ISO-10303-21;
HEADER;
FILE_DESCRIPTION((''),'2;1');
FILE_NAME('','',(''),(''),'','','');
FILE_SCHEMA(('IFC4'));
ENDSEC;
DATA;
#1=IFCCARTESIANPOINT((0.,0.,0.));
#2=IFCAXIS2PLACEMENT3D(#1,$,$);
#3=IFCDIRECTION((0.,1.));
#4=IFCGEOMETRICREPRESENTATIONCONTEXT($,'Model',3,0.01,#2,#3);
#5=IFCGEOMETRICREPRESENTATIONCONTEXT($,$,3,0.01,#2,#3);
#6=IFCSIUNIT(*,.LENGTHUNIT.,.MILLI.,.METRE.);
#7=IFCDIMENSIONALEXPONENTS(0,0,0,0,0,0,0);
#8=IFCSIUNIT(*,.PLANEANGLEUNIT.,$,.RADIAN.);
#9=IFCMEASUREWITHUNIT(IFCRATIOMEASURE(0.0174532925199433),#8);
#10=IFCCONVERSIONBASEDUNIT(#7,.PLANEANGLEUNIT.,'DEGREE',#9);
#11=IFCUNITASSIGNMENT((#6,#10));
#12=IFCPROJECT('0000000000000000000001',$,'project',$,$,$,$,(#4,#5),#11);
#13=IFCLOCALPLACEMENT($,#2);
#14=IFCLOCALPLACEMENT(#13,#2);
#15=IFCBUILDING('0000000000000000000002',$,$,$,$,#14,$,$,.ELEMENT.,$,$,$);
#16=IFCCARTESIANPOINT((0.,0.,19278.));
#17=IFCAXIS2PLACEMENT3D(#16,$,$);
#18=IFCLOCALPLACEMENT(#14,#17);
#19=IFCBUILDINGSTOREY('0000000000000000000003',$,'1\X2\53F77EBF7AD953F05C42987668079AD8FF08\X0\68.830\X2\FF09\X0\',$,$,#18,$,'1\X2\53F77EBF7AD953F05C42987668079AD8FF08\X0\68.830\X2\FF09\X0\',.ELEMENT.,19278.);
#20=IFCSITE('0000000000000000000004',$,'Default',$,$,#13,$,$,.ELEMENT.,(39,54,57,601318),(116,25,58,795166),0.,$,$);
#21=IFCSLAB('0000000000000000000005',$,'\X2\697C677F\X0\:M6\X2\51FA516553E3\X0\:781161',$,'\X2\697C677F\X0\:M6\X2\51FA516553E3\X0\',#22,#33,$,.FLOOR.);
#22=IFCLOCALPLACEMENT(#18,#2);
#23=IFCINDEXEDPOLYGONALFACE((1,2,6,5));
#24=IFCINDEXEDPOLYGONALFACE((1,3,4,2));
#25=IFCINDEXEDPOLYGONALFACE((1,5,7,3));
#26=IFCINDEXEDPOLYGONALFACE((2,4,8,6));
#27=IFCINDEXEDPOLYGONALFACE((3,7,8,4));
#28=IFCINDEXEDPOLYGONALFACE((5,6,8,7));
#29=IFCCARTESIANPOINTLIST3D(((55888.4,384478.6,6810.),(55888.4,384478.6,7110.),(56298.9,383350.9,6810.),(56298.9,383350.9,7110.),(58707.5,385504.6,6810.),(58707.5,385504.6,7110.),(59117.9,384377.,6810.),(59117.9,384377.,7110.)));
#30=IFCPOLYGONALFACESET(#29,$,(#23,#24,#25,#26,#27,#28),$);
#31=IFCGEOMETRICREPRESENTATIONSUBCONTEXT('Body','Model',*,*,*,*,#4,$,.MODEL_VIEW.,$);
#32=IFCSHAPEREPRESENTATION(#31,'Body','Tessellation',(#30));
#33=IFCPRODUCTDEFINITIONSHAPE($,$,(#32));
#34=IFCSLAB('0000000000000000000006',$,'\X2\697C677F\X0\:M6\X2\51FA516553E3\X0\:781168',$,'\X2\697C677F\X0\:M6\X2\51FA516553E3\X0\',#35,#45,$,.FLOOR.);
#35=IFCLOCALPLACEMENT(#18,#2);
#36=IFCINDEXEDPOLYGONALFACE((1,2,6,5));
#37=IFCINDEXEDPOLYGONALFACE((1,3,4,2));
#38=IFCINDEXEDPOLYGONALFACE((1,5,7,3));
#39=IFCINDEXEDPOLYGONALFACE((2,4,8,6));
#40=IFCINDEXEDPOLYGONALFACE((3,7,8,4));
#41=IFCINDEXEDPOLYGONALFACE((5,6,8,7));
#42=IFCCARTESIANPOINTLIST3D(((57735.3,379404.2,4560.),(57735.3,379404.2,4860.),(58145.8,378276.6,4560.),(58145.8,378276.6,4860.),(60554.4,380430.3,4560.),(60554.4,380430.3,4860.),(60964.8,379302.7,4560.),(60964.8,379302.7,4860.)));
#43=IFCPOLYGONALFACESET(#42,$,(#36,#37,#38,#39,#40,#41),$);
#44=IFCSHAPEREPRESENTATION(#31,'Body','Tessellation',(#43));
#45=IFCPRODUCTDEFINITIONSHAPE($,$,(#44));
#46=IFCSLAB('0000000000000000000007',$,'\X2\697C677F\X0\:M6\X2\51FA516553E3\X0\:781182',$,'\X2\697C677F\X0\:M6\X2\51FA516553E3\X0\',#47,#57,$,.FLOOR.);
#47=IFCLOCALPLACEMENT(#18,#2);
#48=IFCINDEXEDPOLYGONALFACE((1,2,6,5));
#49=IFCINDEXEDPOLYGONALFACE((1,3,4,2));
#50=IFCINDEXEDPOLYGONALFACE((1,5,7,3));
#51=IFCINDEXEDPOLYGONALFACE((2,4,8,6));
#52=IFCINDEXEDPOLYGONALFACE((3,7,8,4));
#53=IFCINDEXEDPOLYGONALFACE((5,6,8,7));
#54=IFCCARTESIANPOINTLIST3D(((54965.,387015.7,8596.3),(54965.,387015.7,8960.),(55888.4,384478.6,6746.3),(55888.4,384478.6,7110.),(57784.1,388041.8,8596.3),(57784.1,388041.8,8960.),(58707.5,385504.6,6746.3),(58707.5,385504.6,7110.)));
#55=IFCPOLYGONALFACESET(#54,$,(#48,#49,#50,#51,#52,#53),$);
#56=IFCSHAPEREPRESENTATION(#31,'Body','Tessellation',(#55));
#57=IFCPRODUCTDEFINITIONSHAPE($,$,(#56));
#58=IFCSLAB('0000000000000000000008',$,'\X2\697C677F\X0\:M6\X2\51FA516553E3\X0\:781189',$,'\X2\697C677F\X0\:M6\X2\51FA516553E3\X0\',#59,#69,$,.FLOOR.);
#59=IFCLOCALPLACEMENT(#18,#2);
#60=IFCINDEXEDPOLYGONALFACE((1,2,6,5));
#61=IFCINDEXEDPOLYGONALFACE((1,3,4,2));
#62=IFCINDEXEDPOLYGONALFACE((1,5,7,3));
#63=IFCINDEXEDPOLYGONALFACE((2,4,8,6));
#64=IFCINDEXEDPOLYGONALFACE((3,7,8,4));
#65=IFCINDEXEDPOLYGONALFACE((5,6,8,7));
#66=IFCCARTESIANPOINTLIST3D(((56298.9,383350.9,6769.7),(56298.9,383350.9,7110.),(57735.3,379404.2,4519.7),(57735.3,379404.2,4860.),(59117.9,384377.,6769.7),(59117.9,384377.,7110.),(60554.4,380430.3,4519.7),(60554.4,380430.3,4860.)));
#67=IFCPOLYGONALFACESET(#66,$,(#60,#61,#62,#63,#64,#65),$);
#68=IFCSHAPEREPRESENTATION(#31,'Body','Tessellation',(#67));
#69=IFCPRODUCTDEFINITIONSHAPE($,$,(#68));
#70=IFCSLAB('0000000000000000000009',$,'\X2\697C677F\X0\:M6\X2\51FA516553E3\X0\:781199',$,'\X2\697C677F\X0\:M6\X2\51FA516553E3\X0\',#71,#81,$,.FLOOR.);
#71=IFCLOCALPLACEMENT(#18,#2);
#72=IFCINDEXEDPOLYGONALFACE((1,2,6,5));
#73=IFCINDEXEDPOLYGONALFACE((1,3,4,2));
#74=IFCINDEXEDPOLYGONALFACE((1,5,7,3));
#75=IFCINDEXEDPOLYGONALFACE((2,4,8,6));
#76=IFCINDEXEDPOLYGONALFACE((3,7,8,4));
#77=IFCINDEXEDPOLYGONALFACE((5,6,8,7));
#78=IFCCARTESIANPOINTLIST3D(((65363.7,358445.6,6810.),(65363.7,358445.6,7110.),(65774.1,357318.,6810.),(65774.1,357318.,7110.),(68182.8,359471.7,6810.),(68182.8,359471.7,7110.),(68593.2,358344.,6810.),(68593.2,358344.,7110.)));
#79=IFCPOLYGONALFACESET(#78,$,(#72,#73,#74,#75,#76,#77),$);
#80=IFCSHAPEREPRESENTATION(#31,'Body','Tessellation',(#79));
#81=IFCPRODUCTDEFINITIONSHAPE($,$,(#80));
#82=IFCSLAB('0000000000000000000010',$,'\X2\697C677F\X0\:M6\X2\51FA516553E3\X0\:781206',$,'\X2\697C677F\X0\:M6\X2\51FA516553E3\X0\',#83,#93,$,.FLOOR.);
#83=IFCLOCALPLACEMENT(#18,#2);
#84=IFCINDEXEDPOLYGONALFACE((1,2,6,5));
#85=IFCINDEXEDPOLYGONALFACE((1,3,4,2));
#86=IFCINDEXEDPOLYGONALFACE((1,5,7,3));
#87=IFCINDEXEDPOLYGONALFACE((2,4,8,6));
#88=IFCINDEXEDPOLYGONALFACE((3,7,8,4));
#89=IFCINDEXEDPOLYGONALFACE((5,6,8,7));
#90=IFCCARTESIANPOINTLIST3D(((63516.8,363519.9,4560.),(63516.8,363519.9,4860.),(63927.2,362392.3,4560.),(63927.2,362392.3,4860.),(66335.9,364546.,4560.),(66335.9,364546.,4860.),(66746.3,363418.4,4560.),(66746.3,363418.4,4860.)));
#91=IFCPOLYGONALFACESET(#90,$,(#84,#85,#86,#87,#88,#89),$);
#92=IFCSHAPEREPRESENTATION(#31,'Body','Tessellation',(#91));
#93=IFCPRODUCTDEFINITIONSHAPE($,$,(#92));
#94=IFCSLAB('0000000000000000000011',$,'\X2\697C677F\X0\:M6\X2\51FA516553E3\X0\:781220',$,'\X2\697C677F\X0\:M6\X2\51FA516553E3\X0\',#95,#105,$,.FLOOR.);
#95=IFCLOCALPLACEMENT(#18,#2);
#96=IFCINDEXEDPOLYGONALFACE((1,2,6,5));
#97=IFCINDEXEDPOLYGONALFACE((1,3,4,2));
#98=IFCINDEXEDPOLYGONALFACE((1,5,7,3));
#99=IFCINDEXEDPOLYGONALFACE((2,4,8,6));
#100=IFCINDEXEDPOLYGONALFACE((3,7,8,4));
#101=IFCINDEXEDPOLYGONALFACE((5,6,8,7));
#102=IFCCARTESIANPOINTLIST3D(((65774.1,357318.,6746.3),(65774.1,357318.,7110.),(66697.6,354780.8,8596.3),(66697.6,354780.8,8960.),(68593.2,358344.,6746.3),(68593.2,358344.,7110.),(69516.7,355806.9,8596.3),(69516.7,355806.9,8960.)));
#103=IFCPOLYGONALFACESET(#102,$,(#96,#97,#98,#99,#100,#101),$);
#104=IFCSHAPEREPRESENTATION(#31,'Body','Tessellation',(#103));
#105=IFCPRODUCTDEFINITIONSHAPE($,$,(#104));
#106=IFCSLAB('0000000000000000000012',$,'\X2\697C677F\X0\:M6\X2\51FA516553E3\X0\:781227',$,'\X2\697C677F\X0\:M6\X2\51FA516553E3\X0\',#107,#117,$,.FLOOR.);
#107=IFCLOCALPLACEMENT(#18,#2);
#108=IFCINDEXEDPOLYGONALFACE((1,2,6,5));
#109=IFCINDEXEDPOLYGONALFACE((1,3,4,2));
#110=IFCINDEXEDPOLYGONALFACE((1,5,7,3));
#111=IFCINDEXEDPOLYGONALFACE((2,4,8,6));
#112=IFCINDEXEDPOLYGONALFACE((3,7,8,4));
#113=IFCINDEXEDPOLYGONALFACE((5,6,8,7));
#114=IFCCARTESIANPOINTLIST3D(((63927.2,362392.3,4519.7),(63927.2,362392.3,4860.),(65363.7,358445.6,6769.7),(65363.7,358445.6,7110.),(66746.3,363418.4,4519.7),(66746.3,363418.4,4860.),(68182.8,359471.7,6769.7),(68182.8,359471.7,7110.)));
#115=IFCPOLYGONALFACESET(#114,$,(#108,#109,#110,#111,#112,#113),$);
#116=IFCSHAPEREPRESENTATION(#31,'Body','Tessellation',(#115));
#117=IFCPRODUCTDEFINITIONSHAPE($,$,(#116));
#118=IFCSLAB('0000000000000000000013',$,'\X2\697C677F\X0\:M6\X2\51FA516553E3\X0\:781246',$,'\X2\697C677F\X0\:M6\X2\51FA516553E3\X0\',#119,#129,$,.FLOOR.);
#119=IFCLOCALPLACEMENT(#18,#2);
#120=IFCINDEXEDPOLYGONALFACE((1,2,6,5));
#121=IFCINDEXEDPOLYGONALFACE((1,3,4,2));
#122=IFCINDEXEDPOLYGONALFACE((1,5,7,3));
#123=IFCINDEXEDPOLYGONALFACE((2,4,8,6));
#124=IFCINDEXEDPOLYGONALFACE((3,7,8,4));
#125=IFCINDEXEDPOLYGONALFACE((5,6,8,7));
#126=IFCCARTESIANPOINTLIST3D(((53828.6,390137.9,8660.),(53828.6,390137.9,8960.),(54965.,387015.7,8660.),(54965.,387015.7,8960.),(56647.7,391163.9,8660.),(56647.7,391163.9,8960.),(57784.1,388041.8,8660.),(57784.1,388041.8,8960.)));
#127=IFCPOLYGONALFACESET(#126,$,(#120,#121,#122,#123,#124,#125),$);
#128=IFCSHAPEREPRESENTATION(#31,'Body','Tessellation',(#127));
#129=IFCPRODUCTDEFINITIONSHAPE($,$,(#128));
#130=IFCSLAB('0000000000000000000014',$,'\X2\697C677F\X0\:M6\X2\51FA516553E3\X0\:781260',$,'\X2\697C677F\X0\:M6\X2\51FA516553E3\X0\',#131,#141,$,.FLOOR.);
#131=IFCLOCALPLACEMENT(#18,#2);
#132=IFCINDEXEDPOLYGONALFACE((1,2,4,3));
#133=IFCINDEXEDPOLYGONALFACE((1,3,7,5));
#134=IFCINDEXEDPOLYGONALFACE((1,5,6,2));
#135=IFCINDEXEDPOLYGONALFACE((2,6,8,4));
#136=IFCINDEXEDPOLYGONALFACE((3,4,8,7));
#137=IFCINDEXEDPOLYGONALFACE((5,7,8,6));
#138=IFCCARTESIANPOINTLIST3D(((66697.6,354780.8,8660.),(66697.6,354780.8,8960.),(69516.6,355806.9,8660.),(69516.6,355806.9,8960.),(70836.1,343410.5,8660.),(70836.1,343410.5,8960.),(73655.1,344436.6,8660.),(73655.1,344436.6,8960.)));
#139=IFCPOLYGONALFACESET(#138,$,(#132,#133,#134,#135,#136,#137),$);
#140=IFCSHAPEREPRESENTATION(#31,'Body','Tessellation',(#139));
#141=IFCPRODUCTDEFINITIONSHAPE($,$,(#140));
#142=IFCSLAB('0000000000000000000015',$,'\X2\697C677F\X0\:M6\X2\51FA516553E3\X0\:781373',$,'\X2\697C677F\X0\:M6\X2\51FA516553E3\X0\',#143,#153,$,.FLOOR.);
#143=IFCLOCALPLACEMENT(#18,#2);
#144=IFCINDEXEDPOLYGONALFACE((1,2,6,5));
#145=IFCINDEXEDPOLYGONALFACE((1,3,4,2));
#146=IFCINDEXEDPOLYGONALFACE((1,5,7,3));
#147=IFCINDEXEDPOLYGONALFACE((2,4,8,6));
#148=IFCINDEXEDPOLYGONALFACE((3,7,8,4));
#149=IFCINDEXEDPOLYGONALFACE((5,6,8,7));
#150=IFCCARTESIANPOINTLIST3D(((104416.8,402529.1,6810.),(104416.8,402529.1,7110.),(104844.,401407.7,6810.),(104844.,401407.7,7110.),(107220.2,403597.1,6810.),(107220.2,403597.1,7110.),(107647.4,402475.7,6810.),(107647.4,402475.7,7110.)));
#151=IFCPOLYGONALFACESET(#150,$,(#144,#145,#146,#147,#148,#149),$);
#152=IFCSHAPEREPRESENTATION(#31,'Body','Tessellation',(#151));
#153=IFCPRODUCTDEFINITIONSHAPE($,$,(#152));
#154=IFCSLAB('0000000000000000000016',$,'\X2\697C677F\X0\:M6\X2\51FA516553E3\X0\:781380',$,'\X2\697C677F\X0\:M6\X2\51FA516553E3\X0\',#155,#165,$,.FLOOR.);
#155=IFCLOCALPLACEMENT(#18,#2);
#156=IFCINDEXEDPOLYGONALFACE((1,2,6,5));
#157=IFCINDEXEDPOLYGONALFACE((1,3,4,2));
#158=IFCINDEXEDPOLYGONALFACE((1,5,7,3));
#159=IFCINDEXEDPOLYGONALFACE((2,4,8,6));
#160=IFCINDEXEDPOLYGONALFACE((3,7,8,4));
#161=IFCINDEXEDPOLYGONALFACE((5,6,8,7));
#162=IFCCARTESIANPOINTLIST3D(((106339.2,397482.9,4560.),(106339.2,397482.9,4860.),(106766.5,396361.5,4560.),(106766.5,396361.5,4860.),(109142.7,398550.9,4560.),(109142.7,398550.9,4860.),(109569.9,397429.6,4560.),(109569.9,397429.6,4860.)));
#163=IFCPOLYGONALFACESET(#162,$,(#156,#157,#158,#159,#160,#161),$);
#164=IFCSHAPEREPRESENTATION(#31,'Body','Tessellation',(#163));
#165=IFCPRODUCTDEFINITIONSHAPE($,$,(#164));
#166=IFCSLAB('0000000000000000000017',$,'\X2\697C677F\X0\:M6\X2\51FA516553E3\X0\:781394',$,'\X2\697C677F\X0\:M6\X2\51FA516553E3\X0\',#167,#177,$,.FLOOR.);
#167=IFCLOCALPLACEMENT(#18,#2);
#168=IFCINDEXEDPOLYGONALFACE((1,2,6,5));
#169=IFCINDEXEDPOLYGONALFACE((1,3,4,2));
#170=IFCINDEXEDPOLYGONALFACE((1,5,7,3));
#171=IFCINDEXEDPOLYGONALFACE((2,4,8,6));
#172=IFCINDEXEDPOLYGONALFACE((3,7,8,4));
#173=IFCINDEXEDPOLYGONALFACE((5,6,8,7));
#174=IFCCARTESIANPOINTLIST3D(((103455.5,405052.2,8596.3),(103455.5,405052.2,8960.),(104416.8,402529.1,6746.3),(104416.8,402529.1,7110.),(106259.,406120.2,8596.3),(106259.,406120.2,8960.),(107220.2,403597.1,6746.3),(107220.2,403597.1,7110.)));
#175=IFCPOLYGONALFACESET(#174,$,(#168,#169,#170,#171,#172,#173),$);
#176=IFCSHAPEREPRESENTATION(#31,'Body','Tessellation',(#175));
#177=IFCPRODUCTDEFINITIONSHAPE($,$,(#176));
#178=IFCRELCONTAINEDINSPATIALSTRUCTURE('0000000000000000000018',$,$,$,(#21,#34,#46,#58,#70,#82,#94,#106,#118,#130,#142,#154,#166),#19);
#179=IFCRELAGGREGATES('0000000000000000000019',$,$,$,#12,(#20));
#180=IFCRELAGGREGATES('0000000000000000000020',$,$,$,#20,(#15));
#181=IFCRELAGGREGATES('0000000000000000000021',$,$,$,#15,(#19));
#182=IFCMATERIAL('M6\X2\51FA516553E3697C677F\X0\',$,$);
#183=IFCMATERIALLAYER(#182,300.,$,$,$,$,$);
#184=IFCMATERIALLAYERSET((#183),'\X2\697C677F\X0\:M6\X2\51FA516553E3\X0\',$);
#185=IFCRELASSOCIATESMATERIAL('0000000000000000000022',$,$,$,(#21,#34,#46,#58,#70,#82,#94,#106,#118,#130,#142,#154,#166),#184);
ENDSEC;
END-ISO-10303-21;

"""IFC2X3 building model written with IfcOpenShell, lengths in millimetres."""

from ifc_helpers import new_model, entity, si_unit, converted_unit, direction, frame, frame_2d, origin, place, context, subcontext, project, spatial, polyline, rectangle, outline, extrude, clip, halfspace, material, layer, layer_set, layer_usage, element, save


model = new_model("IFC2X3")

# Units and contexts
model_context = context("Model", 3, precision=0.01, world=origin(), true_north=direction((0.0, 1.0)))
context_of_model = context(None, 3, precision=0.01, world=origin(), true_north=direction((0.0, 1.0)))
body_context = subcontext(model_context, "Body", "Model", "MODEL_VIEW")
ifc_project = project(units=[si_unit("LENGTHUNIT", "METRE", prefix="MILLI"), converted_unit("PLANEANGLEUNIT", "DEGREE", entity("IfcRatioMeasure", 0.0174532925199433), si_unit("PLANEANGLEUNIT", "RADIAN"), dimensions=[0, 0, 0, 0, 0, 0, 0])], contexts=[model_context, context_of_model])

# Site, building, storey
site_placement = place(None, origin())
site = spatial("IfcSite", under=ifc_project, at=site_placement, Name="Default", CompositionType="ELEMENT", RefLatitude=(39, 54, 57, 601318), RefLongitude=(116, 25, 58, 795166), RefElevation=0.0)
building_placement = place(site_placement, origin())
building = spatial("IfcBuilding", under=site, at=building_placement, CompositionType="ELEMENT")
storey_placement = place(building_placement, frame((0.0, 0.0, 19278.0)))
storey = spatial("IfcBuildingStorey", under=building, at=storey_placement, Name="1号线站台层顶标高（68.830）", LongName="1号线站台层顶标高（68.830）", CompositionType="ELEMENT", Elevation=19278.0)

# Slabs
ifc_material_1 = material(Name="M6出入口楼板")
ifc_layer_1 = layer(ifc_material_1, 300.0)
ifc_layer_set_1 = layer_set([ifc_layer_1], Name="楼板:M6出入口")
ifc_layer_usage_1 = layer_usage(ifc_layer_set_1, "AXIS3", "POSITIVE", 0.0)
slab_1_placement = place(storey_placement, origin())
element("IfcSlab", 1, at=slab_1_placement, inside=storey, material=ifc_layer_usage_1, Name="楼板:M6出入口:781161", ObjectType="楼板:M6出入口", PredefinedType="FLOOR", context=body_context, shape_type="SweptSolid", body=[
    extrude(rectangle(XDim=1200.0, YDim=3000.0, at=frame_2d((0.0, 0.0), x_axis=(1.0, 0.0))), frame((57503.2, 384427.8, 7110.0), z_axis=(0.0, 0.0, -1.0), x_axis=(0.34202, -0.939693, 0.0)), (0.0, 0.0, 1.0), 300.0),
])
ifc_layer_usage_2 = layer_usage(ifc_layer_set_1, "AXIS3", "POSITIVE", 0.0)
slab_2_placement = place(storey_placement, origin())
element("IfcSlab", 2, at=slab_2_placement, inside=storey, material=ifc_layer_usage_2, Name="楼板:M6出入口:781168", ObjectType="楼板:M6出入口", PredefinedType="FLOOR", context=body_context, shape_type="SweptSolid", body=[
    extrude(rectangle(XDim=1200.0, YDim=3000.0, at=frame_2d((0.0, 0.0), x_axis=(1.0, 0.0))), frame((59350.1, 379353.4, 4860.0), z_axis=(0.0, 0.0, -1.0), x_axis=(0.34202, -0.939693, 0.0)), (0.0, 0.0, 1.0), 300.0),
])
ifc_layer_usage_3 = layer_usage(ifc_layer_set_1, "AXIS3", "POSITIVE", 0.0)
slab_3_placement = place(storey_placement, origin())
element("IfcSlab", 3, at=slab_3_placement, inside=storey, material=ifc_layer_usage_3, Name="楼板:M6出入口:781182", ObjectType="楼板:M6出入口", PredefinedType="FLOOR", context=body_context, shape_type="Clipping", body=[
    clip(clip(extrude(rectangle(XDim=3273.0, YDim=3000.0, at=frame_2d((0.0, 0.0), x_axis=(1.0, 0.0))), frame((56836.2, 386260.2, 8035.0), z_axis=(-0.193321, 0.531144, -0.824932), x_axis=(0.282143, -0.775183, -0.565231)), (0.565231, 0.0, 0.824932), 440.8), halfspace(frame((56374.5, 387528.8, 8596.3), z_axis=(-0.193321, 0.531144, -0.824932), x_axis=(0.981136, 0.104655, -0.162543)), False)), halfspace(frame((56374.5, 387528.8, 8960.0), z_axis=(0.193321, -0.531144, 0.824932), x_axis=(0.981136, 0.104655, -0.162543)), False)),
])
ifc_layer_usage_4 = layer_usage(ifc_layer_set_1, "AXIS3", "POSITIVE", 0.0)
slab_4_placement = place(storey_placement, origin())
element("IfcSlab", 4, at=slab_4_placement, inside=storey, material=ifc_layer_usage_4, Name="楼板:M6出入口:781189", ObjectType="楼板:M6出入口", PredefinedType="FLOOR", context=body_context, shape_type="Clipping", body=[
    clip(clip(extrude(rectangle(XDim=4764.7, YDim=3000.0, at=frame_2d((0.0, 0.0), x_axis=(1.0, 0.0))), frame((58426.6, 381890.6, 5985.0), z_axis=(-0.161509, 0.443743, -0.88148), x_axis=(0.301484, -0.82832, -0.472221)), (0.472221, 0.0, 0.88148), 386.1), halfspace(frame((57708.4, 383864.0, 6769.7), z_axis=(-0.161509, 0.443743, -0.88148), x_axis=(0.986871, 0.072622, -0.144261)), False)), halfspace(frame((57708.4, 383864.0, 7110.0), z_axis=(0.161509, -0.443743, 0.88148), x_axis=(0.986871, 0.072622, -0.144261)), False)),
])
ifc_layer_usage_5 = layer_usage(ifc_layer_set_1, "AXIS3", "POSITIVE", 0.0)
slab_5_placement = place(storey_placement, origin())
element("IfcSlab", 5, at=slab_5_placement, inside=storey, material=ifc_layer_usage_5, Name="楼板:M6出入口:781199", ObjectType="楼板:M6出入口", PredefinedType="FLOOR", context=body_context, shape_type="SweptSolid", body=[
    extrude(rectangle(XDim=1200.0, YDim=3000.0, at=frame_2d((0.0, 0.0), x_axis=(1.0, 0.0))), frame((66978.5, 358394.8, 7110.0), z_axis=(0.0, 0.0, -1.0), x_axis=(0.342025, -0.939691, 0.0)), (0.0, 0.0, 1.0), 300.0),
])
ifc_layer_usage_6 = layer_usage(ifc_layer_set_1, "AXIS3", "POSITIVE", 0.0)
slab_6_placement = place(storey_placement, origin())
element("IfcSlab", 6, at=slab_6_placement, inside=storey, material=ifc_layer_usage_6, Name="楼板:M6出入口:781206", ObjectType="楼板:M6出入口", PredefinedType="FLOOR", context=body_context, shape_type="SweptSolid", body=[
    extrude(rectangle(XDim=1200.0, YDim=3000.0, at=frame_2d((0.0, 0.0), x_axis=(1.0, 0.0))), frame((65131.5, 363469.1, 4860.0), z_axis=(0.0, 0.0, -1.0), x_axis=(0.342025, -0.939691, 0.0)), (0.0, 0.0, 1.0), 300.0),
])
ifc_layer_usage_7 = layer_usage(ifc_layer_set_1, "AXIS3", "POSITIVE", 0.0)
slab_7_placement = place(storey_placement, origin())
element("IfcSlab", 7, at=slab_7_placement, inside=storey, material=ifc_layer_usage_7, Name="楼板:M6出入口:781220", ObjectType="楼板:M6出入口", PredefinedType="FLOOR", context=body_context, shape_type="Clipping", body=[
    clip(clip(extrude(rectangle(XDim=3273.0, YDim=3000.0, at=frame_2d((0.0, 0.0), x_axis=(1.0, 0.0))), frame((67645.4, 356562.4, 8035.0), z_axis=(0.193323, -0.531143, -0.824932), x_axis=(0.282147, -0.775181, 0.565231)), (-0.565231, 0.0, 0.824932), 440.8), halfspace(frame((68107.1, 355293.8, 8596.3), z_axis=(0.193323, -0.531143, -0.824932), x_axis=(0.981135, 0.104657, 0.162545)), False)), halfspace(frame((68107.1, 355293.8, 8960.0), z_axis=(-0.193323, 0.531143, 0.824932), x_axis=(0.981135, 0.104657, 0.162545)), False)),
])
ifc_layer_usage_8 = layer_usage(ifc_layer_set_1, "AXIS3", "POSITIVE", 0.0)
slab_8_placement = place(storey_placement, origin())
element("IfcSlab", 8, at=slab_8_placement, inside=storey, material=ifc_layer_usage_8, Name="楼板:M6出入口:781227", ObjectType="楼板:M6出入口", PredefinedType="FLOOR", context=body_context, shape_type="Clipping", body=[
    clip(clip(extrude(rectangle(XDim=4764.7, YDim=3000.0, at=frame_2d((0.0, 0.0), x_axis=(1.0, 0.0))), frame((66055.0, 360932.0, 5985.0), z_axis=(0.161511, -0.443742, -0.88148), x_axis=(0.301488, -0.828319, 0.472221)), (-0.472221, 0.0, 0.88148), 386.1), halfspace(frame((66773.2, 358958.6, 6769.7), z_axis=(0.161511, -0.443742, -0.88148), x_axis=(0.986871, 0.072623, 0.144263)), False)), halfspace(frame((66773.2, 358958.6, 7110.0), z_axis=(-0.161511, 0.443742, 0.88148), x_axis=(0.986871, 0.072623, 0.144263)), False)),
])
ifc_layer_usage_9 = layer_usage(ifc_layer_set_1, "AXIS3", "POSITIVE", 0.0)
slab_9_placement = place(storey_placement, origin())
element("IfcSlab", 9, at=slab_9_placement, inside=storey, material=ifc_layer_usage_9, Name="楼板:M6出入口:781246", ObjectType="楼板:M6出入口", PredefinedType="FLOOR", context=body_context, shape_type="SweptSolid", body=[
    extrude(rectangle(XDim=3322.5, YDim=3000.0, at=frame_2d((0.0, 0.0), x_axis=(1.0, 0.0))), frame((55806.3, 389089.8, 8960.0), z_axis=(0.0, 0.0, -1.0), x_axis=(0.34202, -0.939693, 0.0)), (0.0, 0.0, 1.0), 300.0),
])
ifc_layer_usage_10 = layer_usage(ifc_layer_set_1, "AXIS3", "POSITIVE", 0.0)
slab_10_placement = place(storey_placement, origin())
element("IfcSlab", 10, at=slab_10_placement, inside=storey, material=ifc_layer_usage_10, Name="楼板:M6出入口:781260", ObjectType="楼板:M6出入口", PredefinedType="FLOOR", context=body_context, shape_type="SweptSolid", body=[
    extrude(outline(polyline([(-6050.0, -1500.0), (6050.0, -1500.0), (6050.0, 1500.0), (-6050.0, 1499.9), (-6050.0, -1500.0)])), frame((70176.3, 349608.7, 8960.0), z_axis=(0.0, 0.0, -1.0), x_axis=(0.342025, -0.939691, 0.0)), (0.0, 0.0, 1.0), 300.0),
])
ifc_layer_usage_11 = layer_usage(ifc_layer_set_1, "AXIS3", "POSITIVE", 0.0)
slab_11_placement = place(storey_placement, origin())
element("IfcSlab", 11, at=slab_11_placement, inside=storey, material=ifc_layer_usage_11, Name="楼板:M6出入口:781373", ObjectType="楼板:M6出入口", PredefinedType="FLOOR", context=body_context, shape_type="SweptSolid", body=[
    extrude(rectangle(XDim=3000.0, YDim=1200.0, at=frame_2d((0.0, 0.0), x_axis=(1.0, 0.0))), frame((106032.1, 402502.4, 7110.0), z_axis=(0.0, 0.0, -1.0), x_axis=(0.93448, 0.356017, 0.0)), (0.0, 0.0, 1.0), 300.0),
])
ifc_layer_usage_12 = layer_usage(ifc_layer_set_1, "AXIS3", "POSITIVE", 0.0)
slab_12_placement = place(storey_placement, origin())
element("IfcSlab", 12, at=slab_12_placement, inside=storey, material=ifc_layer_usage_12, Name="楼板:M6出入口:781380", ObjectType="楼板:M6出入口", PredefinedType="FLOOR", context=body_context, shape_type="SweptSolid", body=[
    extrude(rectangle(XDim=3000.0, YDim=1200.0, at=frame_2d((0.0, 0.0), x_axis=(1.0, 0.0))), frame((107954.6, 397456.2, 4860.0), z_axis=(0.0, 0.0, -1.0), x_axis=(0.93448, 0.356017, 0.0)), (0.0, 0.0, 1.0), 300.0),
])
ifc_layer_usage_13 = layer_usage(ifc_layer_set_1, "AXIS3", "POSITIVE", 0.0)
slab_13_placement = place(storey_placement, origin())
element("IfcSlab", 13, at=slab_13_placement, inside=storey, material=ifc_layer_usage_13, Name="楼板:M6出入口:781394", ObjectType="楼板:M6出入口", PredefinedType="FLOOR", context=body_context, shape_type="Clipping", body=[
    clip(clip(extrude(rectangle(XDim=3273.0, YDim=3000.0, at=frame_2d((0.0, 0.0), x_axis=(1.0, 0.0))), frame((105337.9, 404324.6, 8035.0), z_axis=(-0.201232, 0.528197, -0.824932), x_axis=(0.29369, -0.770882, -0.565231)), (0.565231, 0.0, 0.824932), 440.8), halfspace(frame((104857.2, 405586.2, 8960.0), z_axis=(0.201232, -0.528197, 0.824932), x_axis=(0.979544, 0.10851, -0.169469)), False)), halfspace(frame((104857.2, 405586.2, 8596.3), z_axis=(-0.201232, 0.528197, -0.824932), x_axis=(0.979544, 0.10851, -0.169469)), False)),
])

save(model, "model.ifc")
